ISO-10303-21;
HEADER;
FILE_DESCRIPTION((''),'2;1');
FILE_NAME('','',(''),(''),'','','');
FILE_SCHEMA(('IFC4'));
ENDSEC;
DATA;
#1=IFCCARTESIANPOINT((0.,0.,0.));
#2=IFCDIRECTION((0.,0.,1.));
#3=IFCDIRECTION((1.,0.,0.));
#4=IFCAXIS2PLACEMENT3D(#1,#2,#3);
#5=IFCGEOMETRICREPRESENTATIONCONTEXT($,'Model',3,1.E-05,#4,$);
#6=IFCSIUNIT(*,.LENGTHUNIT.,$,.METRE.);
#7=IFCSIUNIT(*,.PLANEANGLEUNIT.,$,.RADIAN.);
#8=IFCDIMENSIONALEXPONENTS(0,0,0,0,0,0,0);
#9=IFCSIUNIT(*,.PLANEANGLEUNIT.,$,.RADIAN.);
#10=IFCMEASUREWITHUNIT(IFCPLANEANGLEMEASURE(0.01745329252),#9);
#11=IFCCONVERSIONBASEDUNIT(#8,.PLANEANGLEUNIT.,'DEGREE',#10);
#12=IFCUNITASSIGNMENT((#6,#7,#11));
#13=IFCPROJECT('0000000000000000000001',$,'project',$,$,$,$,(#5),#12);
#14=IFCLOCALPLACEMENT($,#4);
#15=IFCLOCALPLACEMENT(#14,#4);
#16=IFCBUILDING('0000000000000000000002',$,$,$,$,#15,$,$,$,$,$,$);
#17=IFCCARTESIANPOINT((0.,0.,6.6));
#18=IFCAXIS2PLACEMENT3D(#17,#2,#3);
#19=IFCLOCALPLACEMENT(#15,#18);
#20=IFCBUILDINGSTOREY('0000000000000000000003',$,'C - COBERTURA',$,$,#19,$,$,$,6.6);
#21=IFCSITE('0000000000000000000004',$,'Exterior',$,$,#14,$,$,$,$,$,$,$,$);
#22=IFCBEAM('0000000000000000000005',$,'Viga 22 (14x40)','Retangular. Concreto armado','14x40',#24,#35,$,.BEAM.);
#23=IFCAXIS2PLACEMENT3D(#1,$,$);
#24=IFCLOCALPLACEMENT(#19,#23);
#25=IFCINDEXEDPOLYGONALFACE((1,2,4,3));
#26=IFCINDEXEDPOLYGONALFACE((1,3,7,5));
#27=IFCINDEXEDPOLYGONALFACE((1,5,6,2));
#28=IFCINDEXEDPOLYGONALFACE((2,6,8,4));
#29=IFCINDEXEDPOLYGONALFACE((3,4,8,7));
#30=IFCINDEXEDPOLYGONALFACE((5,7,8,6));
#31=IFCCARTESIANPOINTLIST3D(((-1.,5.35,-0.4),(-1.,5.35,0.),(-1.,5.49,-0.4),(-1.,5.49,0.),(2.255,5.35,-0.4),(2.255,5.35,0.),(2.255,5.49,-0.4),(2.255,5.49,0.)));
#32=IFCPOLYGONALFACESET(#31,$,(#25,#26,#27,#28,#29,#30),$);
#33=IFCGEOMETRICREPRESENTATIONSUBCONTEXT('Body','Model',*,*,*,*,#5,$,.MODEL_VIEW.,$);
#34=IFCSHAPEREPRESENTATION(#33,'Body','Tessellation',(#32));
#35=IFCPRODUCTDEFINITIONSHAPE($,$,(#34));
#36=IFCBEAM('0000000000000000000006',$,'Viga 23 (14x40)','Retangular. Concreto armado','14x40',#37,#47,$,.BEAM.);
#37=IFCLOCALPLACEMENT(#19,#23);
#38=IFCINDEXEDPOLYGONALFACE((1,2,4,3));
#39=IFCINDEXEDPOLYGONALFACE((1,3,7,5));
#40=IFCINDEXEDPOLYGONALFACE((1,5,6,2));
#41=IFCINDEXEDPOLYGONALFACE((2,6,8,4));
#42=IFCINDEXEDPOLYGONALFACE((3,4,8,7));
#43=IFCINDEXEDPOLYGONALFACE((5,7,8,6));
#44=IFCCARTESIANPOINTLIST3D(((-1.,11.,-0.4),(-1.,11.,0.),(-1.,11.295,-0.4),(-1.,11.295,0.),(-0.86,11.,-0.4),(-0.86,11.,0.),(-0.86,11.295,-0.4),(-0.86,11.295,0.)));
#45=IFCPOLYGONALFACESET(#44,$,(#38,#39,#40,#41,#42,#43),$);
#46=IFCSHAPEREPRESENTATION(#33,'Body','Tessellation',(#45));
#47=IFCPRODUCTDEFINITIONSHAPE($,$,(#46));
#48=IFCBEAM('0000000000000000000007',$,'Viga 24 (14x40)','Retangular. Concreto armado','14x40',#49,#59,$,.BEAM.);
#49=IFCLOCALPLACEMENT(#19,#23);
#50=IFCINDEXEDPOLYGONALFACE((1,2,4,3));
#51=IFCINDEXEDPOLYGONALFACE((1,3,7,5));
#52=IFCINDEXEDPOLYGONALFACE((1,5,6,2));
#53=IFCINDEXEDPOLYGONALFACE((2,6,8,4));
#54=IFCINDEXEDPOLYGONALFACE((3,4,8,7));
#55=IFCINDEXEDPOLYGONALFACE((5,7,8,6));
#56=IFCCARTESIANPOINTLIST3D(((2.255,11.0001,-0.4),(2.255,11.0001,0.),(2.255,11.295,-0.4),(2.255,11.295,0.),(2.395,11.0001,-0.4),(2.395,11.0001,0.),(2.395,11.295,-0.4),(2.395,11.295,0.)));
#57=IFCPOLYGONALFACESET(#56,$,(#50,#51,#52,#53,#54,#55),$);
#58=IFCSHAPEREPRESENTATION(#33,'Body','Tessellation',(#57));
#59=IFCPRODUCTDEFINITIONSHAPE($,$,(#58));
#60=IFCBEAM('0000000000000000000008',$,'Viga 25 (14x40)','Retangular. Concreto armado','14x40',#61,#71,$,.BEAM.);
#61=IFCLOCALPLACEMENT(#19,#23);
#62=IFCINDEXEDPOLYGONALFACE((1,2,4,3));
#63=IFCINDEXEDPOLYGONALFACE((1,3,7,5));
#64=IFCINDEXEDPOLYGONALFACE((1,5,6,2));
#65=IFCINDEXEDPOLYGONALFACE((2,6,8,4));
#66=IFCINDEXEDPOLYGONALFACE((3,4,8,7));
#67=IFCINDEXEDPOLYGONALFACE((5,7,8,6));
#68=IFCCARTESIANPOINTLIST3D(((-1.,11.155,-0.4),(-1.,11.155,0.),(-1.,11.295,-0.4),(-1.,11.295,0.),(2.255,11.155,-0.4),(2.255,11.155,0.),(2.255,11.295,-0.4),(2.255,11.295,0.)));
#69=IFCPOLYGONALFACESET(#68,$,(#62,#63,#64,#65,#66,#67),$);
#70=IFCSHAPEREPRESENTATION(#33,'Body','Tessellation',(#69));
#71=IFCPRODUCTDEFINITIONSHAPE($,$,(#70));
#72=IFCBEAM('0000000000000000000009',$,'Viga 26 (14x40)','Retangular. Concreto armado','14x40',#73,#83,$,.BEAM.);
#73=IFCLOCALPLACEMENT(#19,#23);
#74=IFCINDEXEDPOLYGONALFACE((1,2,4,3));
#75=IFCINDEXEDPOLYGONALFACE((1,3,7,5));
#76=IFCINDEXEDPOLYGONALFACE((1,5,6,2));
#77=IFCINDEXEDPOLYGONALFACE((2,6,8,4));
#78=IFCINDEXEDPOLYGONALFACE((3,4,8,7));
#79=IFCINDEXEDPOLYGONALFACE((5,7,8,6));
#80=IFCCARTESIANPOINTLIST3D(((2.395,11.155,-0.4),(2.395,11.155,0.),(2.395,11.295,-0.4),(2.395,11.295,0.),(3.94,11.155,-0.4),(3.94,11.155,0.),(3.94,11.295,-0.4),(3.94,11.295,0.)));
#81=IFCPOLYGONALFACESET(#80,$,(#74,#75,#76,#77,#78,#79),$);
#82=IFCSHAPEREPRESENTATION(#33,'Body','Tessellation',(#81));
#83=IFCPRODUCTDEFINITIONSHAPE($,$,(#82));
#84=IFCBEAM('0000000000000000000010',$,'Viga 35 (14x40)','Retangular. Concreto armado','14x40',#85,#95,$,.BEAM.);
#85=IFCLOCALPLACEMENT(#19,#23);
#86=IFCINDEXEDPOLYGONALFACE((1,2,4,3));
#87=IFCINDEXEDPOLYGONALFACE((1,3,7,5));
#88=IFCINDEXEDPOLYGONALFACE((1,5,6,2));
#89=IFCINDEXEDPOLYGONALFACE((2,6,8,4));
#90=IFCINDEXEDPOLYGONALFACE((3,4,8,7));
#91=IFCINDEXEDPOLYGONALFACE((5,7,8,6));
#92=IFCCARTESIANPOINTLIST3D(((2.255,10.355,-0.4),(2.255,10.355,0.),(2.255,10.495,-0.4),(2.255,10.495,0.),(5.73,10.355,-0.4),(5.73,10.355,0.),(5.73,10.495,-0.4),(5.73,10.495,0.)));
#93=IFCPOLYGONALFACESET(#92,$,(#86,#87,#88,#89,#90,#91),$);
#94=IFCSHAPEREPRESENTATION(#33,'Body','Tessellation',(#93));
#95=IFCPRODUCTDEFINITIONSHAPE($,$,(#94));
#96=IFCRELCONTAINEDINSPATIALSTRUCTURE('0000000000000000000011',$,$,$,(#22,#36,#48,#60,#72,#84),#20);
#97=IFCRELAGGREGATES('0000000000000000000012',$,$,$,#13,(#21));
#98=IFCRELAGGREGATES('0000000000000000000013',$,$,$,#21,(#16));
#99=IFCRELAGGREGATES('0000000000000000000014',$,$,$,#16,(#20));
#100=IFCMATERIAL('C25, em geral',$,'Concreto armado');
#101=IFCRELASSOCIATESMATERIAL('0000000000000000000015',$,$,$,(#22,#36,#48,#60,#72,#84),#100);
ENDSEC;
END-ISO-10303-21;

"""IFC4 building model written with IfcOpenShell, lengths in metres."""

from ifc_helpers import new_model, entity, si_unit, converted_unit, frame, frame_2d, origin_with_axes, place, context, subcontext, project, spatial, rectangle, extrude, material, element, save


model = new_model("IFC4")

# Units and contexts
model_context = context("Model", 3, precision=1e-05, world=origin_with_axes())
body_context = subcontext(model_context, "Body", "Model", "MODEL_VIEW")
ifc_project = project(units=[si_unit("LENGTHUNIT", "METRE"), si_unit("PLANEANGLEUNIT", "RADIAN"), converted_unit("PLANEANGLEUNIT", "DEGREE", entity("IfcPlaneAngleMeasure", 0.01745329252), si_unit("PLANEANGLEUNIT", "RADIAN"), dimensions=[0, 0, 0, 0, 0, 0, 0])], contexts=[model_context])

# Site, building, storey
site_placement = place(None, origin_with_axes())
site = spatial("IfcSite", under=ifc_project, at=site_placement, Name="Exterior")
building_placement = place(site_placement, origin_with_axes())
building = spatial("IfcBuilding", under=site, at=building_placement)
storey_placement = place(building_placement, frame((0.0, 0.0, 6.6), z_axis=(0.0, 0.0, 1.0), x_axis=(1.0, 0.0, 0.0)))
storey = spatial("IfcBuildingStorey", under=building, at=storey_placement, Name="C - COBERTURA", Elevation=6.6)

# Shared definitions
ifc_material_1 = material(Name="C25, em geral", Category="Concreto armado")

# Beams
beam_1_placement = place(storey_placement, frame((-1.0, 5.42, 0.0), z_axis=(1.0, 0.0, 0.0), x_axis=(0.0, 1.0, 0.0)))
element("IfcBeam", 1, at=beam_1_placement, inside=storey, material=ifc_material_1, Name="Viga 22 (14x40)", Description="Retangular. Concreto armado", ObjectType="14x40", PredefinedType="BEAM", context=body_context, shape_type="SweptSolid", body=[
    extrude(rectangle(XDim=0.14, YDim=0.4, at=frame_2d((0.0, -0.2), x_axis=(1.0, 0.0))), origin_with_axes(), (0.0, 0.0, 1.0), 3.255),
])
beam_2_placement = place(storey_placement, frame((-0.93, 11.0, 0.0), z_axis=(0.0, 1.0, 0.0), x_axis=(-1.0, 0.0, 0.0)))
element("IfcBeam", 2, at=beam_2_placement, inside=storey, material=ifc_material_1, Name="Viga 23 (14x40)", Description="Retangular. Concreto armado", ObjectType="14x40", PredefinedType="BEAM", context=body_context, shape_type="SweptSolid", body=[
    extrude(rectangle(XDim=0.14, YDim=0.4, at=frame_2d((0.0, -0.2), x_axis=(1.0, 0.0))), origin_with_axes(), (0.0, 0.0, 1.0), 0.295),
])
beam_3_placement = place(storey_placement, frame((2.325, 11.0001, 0.0), z_axis=(0.0, 1.0, 0.0), x_axis=(-1.0, 0.0, 0.0)))
element("IfcBeam", 3, at=beam_3_placement, inside=storey, material=ifc_material_1, Name="Viga 24 (14x40)", Description="Retangular. Concreto armado", ObjectType="14x40", PredefinedType="BEAM", context=body_context, shape_type="SweptSolid", body=[
    extrude(rectangle(XDim=0.14, YDim=0.4, at=frame_2d((0.0, -0.2), x_axis=(1.0, 0.0))), origin_with_axes(), (0.0, 0.0, 1.0), 0.2949),
])
beam_4_placement = place(storey_placement, frame((-1.0, 11.225, 0.0), z_axis=(1.0, 0.0, 0.0), x_axis=(0.0, 1.0, 0.0)))
element("IfcBeam", 4, at=beam_4_placement, inside=storey, material=ifc_material_1, Name="Viga 25 (14x40)", Description="Retangular. Concreto armado", ObjectType="14x40", PredefinedType="BEAM", context=body_context, shape_type="SweptSolid", body=[
    extrude(rectangle(XDim=0.14, YDim=0.4, at=frame_2d((0.0, -0.2), x_axis=(1.0, 0.0))), origin_with_axes(), (0.0, 0.0, 1.0), 3.255),
])
beam_5_placement = place(storey_placement, frame((2.395, 11.225, 0.0), z_axis=(1.0, 0.0, 0.0), x_axis=(0.0, 1.0, 0.0)))
element("IfcBeam", 5, at=beam_5_placement, inside=storey, material=ifc_material_1, Name="Viga 26 (14x40)", Description="Retangular. Concreto armado", ObjectType="14x40", PredefinedType="BEAM", context=body_context, shape_type="SweptSolid", body=[
    extrude(rectangle(XDim=0.14, YDim=0.4, at=frame_2d((0.0, -0.2), x_axis=(1.0, 0.0))), origin_with_axes(), (0.0, 0.0, 1.0), 1.545),
])
beam_6_placement = place(storey_placement, frame((2.255, 10.425, 0.0), z_axis=(1.0, 0.0, 0.0), x_axis=(0.0, 1.0, 0.0)))
element("IfcBeam", 6, at=beam_6_placement, inside=storey, material=ifc_material_1, Name="Viga 35 (14x40)", Description="Retangular. Concreto armado", ObjectType="14x40", PredefinedType="BEAM", context=body_context, shape_type="SweptSolid", body=[
    extrude(rectangle(XDim=0.14, YDim=0.4, at=frame_2d((0.0, -0.2), x_axis=(1.0, 0.0))), origin_with_axes(), (0.0, 0.0, 1.0), 3.475),
])

save(model, "model.ifc")
